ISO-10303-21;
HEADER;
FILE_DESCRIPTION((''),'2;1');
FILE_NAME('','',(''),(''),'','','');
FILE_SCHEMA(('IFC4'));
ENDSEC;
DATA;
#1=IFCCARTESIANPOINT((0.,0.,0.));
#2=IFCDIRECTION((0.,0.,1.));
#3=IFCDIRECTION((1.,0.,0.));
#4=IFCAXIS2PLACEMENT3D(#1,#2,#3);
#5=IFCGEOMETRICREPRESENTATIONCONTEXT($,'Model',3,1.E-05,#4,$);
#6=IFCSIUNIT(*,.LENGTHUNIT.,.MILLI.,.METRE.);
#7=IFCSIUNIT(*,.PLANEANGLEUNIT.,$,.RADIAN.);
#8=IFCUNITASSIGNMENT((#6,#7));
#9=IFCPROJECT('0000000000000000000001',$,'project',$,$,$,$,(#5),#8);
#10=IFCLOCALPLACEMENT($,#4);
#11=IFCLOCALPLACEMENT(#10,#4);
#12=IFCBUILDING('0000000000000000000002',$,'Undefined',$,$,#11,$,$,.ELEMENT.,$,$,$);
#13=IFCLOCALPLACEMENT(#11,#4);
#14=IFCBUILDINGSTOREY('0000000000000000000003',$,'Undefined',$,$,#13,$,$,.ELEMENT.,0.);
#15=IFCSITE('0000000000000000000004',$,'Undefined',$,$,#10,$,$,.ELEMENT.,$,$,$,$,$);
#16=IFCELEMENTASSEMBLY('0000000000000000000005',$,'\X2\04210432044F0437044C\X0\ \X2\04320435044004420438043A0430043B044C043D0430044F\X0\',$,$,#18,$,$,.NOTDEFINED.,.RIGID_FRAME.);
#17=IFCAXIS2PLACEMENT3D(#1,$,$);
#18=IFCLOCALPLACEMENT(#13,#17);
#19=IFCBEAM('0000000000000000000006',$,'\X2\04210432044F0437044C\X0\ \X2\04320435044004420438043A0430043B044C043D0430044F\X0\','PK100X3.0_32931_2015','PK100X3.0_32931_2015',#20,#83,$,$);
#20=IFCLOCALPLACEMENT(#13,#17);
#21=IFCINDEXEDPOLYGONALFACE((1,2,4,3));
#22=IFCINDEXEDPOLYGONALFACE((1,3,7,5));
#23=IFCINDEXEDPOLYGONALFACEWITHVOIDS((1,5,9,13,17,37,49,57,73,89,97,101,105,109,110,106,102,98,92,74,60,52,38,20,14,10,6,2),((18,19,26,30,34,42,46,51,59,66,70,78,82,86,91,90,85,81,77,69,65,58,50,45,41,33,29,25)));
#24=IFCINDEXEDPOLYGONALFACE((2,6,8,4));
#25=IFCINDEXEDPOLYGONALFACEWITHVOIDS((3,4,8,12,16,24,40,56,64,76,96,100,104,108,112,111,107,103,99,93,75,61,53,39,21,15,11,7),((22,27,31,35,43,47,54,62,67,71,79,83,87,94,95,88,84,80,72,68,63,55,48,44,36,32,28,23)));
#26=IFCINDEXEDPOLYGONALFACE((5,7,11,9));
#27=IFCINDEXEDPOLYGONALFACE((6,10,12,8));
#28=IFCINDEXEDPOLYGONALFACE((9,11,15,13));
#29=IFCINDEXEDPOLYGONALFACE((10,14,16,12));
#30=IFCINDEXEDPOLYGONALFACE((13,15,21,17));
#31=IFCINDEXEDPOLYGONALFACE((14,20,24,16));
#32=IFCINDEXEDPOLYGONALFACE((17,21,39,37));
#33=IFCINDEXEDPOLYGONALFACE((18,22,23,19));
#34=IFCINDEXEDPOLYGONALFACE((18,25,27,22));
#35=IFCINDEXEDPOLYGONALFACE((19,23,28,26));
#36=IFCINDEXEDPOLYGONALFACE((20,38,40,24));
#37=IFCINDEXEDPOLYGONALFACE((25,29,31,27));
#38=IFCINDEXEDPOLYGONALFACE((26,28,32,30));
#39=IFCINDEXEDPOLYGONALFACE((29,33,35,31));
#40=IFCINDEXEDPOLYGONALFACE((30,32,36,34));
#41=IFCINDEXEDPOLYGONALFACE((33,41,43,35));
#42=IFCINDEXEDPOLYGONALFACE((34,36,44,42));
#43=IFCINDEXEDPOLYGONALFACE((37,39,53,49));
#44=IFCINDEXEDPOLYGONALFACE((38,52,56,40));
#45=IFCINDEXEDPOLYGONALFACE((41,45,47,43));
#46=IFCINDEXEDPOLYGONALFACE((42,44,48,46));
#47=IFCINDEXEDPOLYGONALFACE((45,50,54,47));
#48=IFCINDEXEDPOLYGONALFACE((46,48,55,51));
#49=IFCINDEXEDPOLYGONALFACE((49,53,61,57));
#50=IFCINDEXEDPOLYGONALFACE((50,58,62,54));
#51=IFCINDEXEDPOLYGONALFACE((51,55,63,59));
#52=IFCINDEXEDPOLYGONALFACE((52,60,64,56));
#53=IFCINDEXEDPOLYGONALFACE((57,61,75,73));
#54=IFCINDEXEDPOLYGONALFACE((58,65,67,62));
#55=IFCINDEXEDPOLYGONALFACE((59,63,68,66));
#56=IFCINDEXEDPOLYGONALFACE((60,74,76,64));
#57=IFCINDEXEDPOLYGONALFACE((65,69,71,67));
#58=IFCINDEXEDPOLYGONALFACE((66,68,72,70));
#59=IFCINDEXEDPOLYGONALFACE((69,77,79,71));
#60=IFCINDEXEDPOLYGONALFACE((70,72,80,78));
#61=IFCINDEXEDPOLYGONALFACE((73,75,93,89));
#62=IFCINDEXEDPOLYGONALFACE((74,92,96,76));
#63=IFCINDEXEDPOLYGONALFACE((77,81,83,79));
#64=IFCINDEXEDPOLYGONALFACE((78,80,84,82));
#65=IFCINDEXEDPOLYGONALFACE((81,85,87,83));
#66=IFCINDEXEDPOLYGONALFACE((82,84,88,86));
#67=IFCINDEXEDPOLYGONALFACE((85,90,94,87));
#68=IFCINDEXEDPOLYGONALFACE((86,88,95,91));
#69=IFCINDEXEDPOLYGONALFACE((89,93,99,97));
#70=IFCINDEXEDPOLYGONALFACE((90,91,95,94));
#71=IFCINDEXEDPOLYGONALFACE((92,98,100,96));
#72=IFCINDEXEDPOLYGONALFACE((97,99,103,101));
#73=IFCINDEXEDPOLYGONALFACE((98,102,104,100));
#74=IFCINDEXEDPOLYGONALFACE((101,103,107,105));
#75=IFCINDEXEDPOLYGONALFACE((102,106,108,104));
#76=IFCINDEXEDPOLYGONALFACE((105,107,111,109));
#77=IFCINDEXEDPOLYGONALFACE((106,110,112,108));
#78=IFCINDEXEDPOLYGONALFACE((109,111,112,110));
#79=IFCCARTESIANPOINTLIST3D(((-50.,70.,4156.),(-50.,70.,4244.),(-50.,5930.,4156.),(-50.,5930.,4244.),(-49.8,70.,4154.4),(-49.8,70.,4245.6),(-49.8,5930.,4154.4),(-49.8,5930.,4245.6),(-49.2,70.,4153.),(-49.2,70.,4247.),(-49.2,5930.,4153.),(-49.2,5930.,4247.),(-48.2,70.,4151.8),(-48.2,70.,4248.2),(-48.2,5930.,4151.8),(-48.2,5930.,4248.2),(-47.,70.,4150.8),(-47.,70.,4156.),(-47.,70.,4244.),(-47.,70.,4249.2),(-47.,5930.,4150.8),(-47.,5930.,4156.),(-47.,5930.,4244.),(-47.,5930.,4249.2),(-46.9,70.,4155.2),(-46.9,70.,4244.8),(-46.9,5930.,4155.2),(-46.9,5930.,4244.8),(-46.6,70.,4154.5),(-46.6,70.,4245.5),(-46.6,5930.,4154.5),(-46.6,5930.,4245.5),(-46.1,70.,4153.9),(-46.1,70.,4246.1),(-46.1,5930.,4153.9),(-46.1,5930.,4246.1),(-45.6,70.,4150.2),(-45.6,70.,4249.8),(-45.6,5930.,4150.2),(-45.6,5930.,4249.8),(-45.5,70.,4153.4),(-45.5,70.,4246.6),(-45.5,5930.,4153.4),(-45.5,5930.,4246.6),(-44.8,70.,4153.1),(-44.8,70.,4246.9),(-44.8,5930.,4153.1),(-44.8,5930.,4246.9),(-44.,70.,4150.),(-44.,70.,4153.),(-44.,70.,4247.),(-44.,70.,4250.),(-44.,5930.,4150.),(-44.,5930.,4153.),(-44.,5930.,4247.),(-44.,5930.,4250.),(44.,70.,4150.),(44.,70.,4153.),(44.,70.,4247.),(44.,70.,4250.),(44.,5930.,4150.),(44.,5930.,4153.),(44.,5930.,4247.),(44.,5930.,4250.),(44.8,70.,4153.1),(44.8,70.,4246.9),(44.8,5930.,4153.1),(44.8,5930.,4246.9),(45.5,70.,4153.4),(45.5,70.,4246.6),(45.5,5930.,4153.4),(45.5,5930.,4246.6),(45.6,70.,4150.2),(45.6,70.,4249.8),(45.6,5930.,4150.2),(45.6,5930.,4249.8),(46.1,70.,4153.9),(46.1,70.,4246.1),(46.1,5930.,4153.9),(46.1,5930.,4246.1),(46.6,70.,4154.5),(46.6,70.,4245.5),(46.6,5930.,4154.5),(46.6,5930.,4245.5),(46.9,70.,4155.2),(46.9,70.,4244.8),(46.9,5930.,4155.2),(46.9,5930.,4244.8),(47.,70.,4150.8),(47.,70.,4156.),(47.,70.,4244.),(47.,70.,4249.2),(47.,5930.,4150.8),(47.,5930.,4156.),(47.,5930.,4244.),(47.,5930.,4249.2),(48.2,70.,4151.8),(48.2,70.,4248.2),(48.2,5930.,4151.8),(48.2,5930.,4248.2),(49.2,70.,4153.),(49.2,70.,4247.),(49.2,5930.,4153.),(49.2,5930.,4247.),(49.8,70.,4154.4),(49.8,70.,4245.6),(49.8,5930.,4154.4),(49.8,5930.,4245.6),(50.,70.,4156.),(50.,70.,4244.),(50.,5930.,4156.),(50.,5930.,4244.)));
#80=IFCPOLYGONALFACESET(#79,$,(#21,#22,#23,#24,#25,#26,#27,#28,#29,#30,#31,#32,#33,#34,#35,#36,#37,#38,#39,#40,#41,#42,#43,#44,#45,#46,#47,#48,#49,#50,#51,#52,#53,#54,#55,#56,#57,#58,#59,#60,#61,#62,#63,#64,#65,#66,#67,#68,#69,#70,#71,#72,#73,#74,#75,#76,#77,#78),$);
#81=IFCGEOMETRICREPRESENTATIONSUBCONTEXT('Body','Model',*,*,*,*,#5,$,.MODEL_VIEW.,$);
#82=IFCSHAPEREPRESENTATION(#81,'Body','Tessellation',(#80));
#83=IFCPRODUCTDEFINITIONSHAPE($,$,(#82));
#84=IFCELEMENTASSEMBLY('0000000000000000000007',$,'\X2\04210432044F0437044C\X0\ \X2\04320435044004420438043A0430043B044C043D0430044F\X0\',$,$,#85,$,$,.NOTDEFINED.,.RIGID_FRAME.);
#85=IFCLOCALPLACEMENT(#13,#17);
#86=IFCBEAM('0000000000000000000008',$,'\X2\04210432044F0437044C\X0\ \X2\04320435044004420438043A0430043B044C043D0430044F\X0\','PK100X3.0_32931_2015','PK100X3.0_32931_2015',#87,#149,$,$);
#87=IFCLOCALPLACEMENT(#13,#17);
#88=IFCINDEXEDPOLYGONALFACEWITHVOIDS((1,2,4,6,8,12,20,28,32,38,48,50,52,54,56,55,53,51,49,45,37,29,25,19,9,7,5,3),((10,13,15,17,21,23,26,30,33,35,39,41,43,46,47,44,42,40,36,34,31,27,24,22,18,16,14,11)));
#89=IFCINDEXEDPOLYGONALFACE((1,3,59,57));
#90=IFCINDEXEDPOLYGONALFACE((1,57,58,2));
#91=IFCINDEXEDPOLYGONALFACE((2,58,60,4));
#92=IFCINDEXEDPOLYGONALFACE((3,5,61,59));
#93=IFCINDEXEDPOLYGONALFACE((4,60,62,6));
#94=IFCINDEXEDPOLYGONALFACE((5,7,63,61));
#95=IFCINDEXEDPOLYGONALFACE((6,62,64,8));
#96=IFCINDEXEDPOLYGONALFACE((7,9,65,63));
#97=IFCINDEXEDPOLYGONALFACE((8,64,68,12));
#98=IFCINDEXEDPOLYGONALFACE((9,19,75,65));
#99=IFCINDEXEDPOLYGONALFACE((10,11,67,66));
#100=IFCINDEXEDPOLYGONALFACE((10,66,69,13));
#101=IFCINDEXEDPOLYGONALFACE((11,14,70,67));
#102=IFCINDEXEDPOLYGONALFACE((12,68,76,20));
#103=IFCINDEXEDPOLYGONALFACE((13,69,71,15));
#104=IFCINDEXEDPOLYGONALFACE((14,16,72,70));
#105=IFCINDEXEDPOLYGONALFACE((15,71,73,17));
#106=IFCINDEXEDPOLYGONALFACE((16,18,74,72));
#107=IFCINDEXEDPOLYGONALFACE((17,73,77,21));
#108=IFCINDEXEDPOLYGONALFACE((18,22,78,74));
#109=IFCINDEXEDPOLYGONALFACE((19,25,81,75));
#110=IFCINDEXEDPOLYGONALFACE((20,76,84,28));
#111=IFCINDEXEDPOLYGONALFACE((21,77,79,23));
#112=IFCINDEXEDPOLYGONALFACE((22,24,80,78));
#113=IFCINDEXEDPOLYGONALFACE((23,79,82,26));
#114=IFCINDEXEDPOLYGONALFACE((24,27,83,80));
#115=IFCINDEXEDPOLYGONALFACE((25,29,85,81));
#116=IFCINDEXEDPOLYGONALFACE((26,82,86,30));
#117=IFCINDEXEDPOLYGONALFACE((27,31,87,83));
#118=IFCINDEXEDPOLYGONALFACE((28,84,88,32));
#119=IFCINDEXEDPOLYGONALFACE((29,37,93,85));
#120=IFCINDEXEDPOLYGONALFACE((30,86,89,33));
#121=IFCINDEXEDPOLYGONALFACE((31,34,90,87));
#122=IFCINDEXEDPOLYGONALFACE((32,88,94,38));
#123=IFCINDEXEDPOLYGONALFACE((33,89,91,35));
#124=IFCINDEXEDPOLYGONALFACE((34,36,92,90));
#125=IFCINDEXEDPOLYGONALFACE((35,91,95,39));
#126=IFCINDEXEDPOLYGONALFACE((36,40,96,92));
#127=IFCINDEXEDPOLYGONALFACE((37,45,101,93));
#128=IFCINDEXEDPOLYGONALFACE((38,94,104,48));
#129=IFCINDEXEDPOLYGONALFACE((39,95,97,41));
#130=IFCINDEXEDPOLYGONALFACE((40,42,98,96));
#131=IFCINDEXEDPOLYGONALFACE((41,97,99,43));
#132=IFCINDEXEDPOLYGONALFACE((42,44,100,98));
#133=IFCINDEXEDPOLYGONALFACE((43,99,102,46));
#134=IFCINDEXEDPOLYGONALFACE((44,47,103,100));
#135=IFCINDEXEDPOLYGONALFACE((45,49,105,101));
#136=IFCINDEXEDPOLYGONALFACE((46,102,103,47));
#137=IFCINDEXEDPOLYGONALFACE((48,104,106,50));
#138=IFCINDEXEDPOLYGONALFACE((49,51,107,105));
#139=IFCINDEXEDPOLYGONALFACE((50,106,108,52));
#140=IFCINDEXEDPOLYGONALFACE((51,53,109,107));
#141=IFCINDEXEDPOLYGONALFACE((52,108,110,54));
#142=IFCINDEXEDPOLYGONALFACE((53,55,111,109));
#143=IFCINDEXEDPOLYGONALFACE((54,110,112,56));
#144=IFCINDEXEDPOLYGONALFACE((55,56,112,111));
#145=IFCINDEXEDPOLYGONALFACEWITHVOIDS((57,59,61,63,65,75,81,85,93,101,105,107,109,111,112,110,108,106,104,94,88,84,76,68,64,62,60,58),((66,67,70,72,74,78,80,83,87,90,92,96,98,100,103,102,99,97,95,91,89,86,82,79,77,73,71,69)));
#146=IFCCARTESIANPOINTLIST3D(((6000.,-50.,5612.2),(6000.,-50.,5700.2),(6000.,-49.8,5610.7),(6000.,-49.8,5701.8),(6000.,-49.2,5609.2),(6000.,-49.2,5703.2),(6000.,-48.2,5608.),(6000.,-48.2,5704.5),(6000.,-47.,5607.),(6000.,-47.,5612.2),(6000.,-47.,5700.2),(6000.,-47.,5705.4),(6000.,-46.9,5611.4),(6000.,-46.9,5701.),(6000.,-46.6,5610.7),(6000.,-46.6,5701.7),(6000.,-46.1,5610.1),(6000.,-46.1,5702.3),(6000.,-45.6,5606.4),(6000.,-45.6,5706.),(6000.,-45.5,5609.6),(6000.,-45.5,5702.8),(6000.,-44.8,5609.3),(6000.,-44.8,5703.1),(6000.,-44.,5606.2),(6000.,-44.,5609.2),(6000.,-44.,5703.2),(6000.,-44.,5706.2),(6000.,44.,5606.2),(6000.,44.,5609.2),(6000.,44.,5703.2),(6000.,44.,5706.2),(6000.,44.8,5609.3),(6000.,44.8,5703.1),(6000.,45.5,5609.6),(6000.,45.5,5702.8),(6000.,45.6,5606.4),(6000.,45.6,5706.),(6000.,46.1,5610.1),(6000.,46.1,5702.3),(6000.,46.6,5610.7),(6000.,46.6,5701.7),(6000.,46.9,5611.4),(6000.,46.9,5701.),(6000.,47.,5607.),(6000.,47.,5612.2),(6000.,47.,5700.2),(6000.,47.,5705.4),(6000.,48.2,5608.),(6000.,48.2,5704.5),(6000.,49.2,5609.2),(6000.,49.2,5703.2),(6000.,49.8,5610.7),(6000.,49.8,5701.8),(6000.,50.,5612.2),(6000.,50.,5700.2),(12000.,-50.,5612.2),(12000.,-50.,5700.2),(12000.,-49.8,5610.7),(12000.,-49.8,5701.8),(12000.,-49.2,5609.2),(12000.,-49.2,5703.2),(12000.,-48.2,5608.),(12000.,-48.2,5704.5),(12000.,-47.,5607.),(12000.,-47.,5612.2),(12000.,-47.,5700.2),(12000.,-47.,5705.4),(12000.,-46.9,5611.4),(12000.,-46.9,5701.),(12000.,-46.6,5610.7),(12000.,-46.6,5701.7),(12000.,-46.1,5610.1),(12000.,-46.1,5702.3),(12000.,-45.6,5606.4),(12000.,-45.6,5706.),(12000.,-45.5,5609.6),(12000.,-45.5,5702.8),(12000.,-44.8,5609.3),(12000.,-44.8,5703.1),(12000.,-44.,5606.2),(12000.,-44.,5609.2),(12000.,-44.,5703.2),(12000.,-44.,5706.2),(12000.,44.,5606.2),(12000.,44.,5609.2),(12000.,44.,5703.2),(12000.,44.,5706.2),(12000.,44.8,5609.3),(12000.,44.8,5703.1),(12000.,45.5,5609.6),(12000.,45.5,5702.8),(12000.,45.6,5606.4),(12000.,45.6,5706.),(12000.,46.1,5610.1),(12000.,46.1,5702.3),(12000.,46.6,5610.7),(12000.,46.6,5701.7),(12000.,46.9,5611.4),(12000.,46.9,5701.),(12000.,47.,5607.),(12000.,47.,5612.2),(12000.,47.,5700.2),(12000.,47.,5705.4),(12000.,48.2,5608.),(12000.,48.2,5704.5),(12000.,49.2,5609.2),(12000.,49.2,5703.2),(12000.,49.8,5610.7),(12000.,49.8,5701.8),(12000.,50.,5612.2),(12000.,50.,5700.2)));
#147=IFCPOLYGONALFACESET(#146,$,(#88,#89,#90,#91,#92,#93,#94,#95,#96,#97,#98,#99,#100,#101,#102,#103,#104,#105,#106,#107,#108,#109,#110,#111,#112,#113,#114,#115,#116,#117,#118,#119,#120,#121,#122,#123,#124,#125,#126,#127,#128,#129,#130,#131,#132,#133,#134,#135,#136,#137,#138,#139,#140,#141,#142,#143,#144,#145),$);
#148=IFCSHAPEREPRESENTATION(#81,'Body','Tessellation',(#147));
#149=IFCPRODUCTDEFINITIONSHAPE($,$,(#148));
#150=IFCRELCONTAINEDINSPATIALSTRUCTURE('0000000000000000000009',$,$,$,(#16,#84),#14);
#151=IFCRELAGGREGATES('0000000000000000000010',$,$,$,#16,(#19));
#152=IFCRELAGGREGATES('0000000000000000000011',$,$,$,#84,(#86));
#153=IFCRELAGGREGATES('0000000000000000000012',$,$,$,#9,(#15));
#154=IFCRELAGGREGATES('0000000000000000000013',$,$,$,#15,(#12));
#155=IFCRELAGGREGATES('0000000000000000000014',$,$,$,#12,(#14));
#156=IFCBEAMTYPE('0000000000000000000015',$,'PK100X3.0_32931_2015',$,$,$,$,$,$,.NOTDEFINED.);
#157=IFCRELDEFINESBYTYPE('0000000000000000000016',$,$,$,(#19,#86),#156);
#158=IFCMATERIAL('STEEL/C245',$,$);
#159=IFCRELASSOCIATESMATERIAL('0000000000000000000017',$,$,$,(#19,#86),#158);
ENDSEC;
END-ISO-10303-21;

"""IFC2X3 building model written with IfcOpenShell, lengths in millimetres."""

from ifc_helpers import new_model, si_unit, frame, origin_with_axes, origin_2d_with_axis, place, context, subcontext, project, spatial, hollow_rectangle, extrude, clip, halfspace, material, type_object, element, aggregate, save


model = new_model("IFC2X3")

# Units and contexts
model_context = context("Model", 3, precision=1e-05, world=origin_with_axes())
body_context = subcontext(model_context, "Body", "Model", "MODEL_VIEW")
ifc_project = project(units=[si_unit("LENGTHUNIT", "METRE", prefix="MILLI"), si_unit("PLANEANGLEUNIT", "RADIAN")], contexts=[model_context])

# Site, building, storey
site_placement = place(None, origin_with_axes())
site = spatial("IfcSite", under=ifc_project, at=site_placement, Name="Undefined", CompositionType="ELEMENT")
building_placement = place(site_placement, origin_with_axes())
building = spatial("IfcBuilding", under=site, at=building_placement, Name="Undefined", CompositionType="ELEMENT")
storey_placement = place(building_placement, origin_with_axes())
storey = spatial("IfcBuildingStorey", under=building, at=storey_placement, Name="Undefined", CompositionType="ELEMENT", Elevation=0.0)

# Element assemblies, beams
ifc_material_1 = material(Name="STEEL/C245")
beam_type_1 = type_object("IfcBeamType", Name="PK100X3.0_32931_2015", PredefinedType="NOTDEFINED")
assembly_1_placement = place(storey_placement, origin_with_axes())
assembly_1 = element("IfcElementAssembly", 1, at=assembly_1_placement, inside=storey, Name="Связь вертикальная", AssemblyPlace="NOTDEFINED", PredefinedType="RIGID_FRAME")
beam_1_placement = place(assembly_1_placement, frame((0.0, 0.0, 4200.0), z_axis=(0.0, 0.0, 1.0), x_axis=(0.0, 1.0, 0.0)))
beam_1 = element("IfcBeam", 2, at=beam_1_placement, type_object=beam_type_1, material=ifc_material_1, Name="Связь вертикальная", Description="PK100X3.0_32931_2015", ObjectType="PK100X3.0_32931_2015", context=body_context, shape_type="Clipping", body=[
    clip(clip(extrude(hollow_rectangle(XDim=100.0, YDim=100.0, WallThickness=3.0, InnerFilletRadius=3.0, OuterFilletRadius=6.0, at=origin_2d_with_axis()), frame((5930.0, 0.0, 0.0), z_axis=(-1.0, 0.0, 0.0), x_axis=(0.0, -1.0, 0.0)), (0.0, 0.0, 1.0), 5860.0), halfspace(frame((5930.0, 0.0, -164.1), z_axis=(-1.0, 0.0, 0.0), x_axis=(0.0, 0.0, 1.0)), True)), halfspace(frame((70.0, 0.0, 380.8), z_axis=(-1.0, 0.0, 0.0), x_axis=(0.0, 0.0, 1.0)), False)),
])
aggregate(assembly_1, [beam_1])
assembly_2_placement = place(storey_placement, origin_with_axes())
assembly_2 = element("IfcElementAssembly", 3, at=assembly_2_placement, inside=storey, Name="Связь вертикальная", AssemblyPlace="NOTDEFINED", PredefinedType="RIGID_FRAME")
beam_2_placement = place(assembly_2_placement, frame((6000.0, 0.0, 5656.2), z_axis=(0.0, 0.0, 1.0), x_axis=(1.0, 0.0, 0.0)))
beam_2 = element("IfcBeam", 4, at=beam_2_placement, type_object=beam_type_1, material=ifc_material_1, Name="Связь вертикальная", Description="PK100X3.0_32931_2015", ObjectType="PK100X3.0_32931_2015", context=body_context, shape_type="SweptSolid", body=[
    extrude(hollow_rectangle(XDim=100.0, YDim=100.0, WallThickness=3.0, InnerFilletRadius=3.0, OuterFilletRadius=6.0, at=origin_2d_with_axis()), frame((6000.0, 0.0, 0.0), z_axis=(-1.0, 0.0, 0.0), x_axis=(0.0, -1.0, 0.0)), (0.0, 0.0, 1.0), 6000.0),
])
aggregate(assembly_2, [beam_2])

save(model, "model.ifc")
